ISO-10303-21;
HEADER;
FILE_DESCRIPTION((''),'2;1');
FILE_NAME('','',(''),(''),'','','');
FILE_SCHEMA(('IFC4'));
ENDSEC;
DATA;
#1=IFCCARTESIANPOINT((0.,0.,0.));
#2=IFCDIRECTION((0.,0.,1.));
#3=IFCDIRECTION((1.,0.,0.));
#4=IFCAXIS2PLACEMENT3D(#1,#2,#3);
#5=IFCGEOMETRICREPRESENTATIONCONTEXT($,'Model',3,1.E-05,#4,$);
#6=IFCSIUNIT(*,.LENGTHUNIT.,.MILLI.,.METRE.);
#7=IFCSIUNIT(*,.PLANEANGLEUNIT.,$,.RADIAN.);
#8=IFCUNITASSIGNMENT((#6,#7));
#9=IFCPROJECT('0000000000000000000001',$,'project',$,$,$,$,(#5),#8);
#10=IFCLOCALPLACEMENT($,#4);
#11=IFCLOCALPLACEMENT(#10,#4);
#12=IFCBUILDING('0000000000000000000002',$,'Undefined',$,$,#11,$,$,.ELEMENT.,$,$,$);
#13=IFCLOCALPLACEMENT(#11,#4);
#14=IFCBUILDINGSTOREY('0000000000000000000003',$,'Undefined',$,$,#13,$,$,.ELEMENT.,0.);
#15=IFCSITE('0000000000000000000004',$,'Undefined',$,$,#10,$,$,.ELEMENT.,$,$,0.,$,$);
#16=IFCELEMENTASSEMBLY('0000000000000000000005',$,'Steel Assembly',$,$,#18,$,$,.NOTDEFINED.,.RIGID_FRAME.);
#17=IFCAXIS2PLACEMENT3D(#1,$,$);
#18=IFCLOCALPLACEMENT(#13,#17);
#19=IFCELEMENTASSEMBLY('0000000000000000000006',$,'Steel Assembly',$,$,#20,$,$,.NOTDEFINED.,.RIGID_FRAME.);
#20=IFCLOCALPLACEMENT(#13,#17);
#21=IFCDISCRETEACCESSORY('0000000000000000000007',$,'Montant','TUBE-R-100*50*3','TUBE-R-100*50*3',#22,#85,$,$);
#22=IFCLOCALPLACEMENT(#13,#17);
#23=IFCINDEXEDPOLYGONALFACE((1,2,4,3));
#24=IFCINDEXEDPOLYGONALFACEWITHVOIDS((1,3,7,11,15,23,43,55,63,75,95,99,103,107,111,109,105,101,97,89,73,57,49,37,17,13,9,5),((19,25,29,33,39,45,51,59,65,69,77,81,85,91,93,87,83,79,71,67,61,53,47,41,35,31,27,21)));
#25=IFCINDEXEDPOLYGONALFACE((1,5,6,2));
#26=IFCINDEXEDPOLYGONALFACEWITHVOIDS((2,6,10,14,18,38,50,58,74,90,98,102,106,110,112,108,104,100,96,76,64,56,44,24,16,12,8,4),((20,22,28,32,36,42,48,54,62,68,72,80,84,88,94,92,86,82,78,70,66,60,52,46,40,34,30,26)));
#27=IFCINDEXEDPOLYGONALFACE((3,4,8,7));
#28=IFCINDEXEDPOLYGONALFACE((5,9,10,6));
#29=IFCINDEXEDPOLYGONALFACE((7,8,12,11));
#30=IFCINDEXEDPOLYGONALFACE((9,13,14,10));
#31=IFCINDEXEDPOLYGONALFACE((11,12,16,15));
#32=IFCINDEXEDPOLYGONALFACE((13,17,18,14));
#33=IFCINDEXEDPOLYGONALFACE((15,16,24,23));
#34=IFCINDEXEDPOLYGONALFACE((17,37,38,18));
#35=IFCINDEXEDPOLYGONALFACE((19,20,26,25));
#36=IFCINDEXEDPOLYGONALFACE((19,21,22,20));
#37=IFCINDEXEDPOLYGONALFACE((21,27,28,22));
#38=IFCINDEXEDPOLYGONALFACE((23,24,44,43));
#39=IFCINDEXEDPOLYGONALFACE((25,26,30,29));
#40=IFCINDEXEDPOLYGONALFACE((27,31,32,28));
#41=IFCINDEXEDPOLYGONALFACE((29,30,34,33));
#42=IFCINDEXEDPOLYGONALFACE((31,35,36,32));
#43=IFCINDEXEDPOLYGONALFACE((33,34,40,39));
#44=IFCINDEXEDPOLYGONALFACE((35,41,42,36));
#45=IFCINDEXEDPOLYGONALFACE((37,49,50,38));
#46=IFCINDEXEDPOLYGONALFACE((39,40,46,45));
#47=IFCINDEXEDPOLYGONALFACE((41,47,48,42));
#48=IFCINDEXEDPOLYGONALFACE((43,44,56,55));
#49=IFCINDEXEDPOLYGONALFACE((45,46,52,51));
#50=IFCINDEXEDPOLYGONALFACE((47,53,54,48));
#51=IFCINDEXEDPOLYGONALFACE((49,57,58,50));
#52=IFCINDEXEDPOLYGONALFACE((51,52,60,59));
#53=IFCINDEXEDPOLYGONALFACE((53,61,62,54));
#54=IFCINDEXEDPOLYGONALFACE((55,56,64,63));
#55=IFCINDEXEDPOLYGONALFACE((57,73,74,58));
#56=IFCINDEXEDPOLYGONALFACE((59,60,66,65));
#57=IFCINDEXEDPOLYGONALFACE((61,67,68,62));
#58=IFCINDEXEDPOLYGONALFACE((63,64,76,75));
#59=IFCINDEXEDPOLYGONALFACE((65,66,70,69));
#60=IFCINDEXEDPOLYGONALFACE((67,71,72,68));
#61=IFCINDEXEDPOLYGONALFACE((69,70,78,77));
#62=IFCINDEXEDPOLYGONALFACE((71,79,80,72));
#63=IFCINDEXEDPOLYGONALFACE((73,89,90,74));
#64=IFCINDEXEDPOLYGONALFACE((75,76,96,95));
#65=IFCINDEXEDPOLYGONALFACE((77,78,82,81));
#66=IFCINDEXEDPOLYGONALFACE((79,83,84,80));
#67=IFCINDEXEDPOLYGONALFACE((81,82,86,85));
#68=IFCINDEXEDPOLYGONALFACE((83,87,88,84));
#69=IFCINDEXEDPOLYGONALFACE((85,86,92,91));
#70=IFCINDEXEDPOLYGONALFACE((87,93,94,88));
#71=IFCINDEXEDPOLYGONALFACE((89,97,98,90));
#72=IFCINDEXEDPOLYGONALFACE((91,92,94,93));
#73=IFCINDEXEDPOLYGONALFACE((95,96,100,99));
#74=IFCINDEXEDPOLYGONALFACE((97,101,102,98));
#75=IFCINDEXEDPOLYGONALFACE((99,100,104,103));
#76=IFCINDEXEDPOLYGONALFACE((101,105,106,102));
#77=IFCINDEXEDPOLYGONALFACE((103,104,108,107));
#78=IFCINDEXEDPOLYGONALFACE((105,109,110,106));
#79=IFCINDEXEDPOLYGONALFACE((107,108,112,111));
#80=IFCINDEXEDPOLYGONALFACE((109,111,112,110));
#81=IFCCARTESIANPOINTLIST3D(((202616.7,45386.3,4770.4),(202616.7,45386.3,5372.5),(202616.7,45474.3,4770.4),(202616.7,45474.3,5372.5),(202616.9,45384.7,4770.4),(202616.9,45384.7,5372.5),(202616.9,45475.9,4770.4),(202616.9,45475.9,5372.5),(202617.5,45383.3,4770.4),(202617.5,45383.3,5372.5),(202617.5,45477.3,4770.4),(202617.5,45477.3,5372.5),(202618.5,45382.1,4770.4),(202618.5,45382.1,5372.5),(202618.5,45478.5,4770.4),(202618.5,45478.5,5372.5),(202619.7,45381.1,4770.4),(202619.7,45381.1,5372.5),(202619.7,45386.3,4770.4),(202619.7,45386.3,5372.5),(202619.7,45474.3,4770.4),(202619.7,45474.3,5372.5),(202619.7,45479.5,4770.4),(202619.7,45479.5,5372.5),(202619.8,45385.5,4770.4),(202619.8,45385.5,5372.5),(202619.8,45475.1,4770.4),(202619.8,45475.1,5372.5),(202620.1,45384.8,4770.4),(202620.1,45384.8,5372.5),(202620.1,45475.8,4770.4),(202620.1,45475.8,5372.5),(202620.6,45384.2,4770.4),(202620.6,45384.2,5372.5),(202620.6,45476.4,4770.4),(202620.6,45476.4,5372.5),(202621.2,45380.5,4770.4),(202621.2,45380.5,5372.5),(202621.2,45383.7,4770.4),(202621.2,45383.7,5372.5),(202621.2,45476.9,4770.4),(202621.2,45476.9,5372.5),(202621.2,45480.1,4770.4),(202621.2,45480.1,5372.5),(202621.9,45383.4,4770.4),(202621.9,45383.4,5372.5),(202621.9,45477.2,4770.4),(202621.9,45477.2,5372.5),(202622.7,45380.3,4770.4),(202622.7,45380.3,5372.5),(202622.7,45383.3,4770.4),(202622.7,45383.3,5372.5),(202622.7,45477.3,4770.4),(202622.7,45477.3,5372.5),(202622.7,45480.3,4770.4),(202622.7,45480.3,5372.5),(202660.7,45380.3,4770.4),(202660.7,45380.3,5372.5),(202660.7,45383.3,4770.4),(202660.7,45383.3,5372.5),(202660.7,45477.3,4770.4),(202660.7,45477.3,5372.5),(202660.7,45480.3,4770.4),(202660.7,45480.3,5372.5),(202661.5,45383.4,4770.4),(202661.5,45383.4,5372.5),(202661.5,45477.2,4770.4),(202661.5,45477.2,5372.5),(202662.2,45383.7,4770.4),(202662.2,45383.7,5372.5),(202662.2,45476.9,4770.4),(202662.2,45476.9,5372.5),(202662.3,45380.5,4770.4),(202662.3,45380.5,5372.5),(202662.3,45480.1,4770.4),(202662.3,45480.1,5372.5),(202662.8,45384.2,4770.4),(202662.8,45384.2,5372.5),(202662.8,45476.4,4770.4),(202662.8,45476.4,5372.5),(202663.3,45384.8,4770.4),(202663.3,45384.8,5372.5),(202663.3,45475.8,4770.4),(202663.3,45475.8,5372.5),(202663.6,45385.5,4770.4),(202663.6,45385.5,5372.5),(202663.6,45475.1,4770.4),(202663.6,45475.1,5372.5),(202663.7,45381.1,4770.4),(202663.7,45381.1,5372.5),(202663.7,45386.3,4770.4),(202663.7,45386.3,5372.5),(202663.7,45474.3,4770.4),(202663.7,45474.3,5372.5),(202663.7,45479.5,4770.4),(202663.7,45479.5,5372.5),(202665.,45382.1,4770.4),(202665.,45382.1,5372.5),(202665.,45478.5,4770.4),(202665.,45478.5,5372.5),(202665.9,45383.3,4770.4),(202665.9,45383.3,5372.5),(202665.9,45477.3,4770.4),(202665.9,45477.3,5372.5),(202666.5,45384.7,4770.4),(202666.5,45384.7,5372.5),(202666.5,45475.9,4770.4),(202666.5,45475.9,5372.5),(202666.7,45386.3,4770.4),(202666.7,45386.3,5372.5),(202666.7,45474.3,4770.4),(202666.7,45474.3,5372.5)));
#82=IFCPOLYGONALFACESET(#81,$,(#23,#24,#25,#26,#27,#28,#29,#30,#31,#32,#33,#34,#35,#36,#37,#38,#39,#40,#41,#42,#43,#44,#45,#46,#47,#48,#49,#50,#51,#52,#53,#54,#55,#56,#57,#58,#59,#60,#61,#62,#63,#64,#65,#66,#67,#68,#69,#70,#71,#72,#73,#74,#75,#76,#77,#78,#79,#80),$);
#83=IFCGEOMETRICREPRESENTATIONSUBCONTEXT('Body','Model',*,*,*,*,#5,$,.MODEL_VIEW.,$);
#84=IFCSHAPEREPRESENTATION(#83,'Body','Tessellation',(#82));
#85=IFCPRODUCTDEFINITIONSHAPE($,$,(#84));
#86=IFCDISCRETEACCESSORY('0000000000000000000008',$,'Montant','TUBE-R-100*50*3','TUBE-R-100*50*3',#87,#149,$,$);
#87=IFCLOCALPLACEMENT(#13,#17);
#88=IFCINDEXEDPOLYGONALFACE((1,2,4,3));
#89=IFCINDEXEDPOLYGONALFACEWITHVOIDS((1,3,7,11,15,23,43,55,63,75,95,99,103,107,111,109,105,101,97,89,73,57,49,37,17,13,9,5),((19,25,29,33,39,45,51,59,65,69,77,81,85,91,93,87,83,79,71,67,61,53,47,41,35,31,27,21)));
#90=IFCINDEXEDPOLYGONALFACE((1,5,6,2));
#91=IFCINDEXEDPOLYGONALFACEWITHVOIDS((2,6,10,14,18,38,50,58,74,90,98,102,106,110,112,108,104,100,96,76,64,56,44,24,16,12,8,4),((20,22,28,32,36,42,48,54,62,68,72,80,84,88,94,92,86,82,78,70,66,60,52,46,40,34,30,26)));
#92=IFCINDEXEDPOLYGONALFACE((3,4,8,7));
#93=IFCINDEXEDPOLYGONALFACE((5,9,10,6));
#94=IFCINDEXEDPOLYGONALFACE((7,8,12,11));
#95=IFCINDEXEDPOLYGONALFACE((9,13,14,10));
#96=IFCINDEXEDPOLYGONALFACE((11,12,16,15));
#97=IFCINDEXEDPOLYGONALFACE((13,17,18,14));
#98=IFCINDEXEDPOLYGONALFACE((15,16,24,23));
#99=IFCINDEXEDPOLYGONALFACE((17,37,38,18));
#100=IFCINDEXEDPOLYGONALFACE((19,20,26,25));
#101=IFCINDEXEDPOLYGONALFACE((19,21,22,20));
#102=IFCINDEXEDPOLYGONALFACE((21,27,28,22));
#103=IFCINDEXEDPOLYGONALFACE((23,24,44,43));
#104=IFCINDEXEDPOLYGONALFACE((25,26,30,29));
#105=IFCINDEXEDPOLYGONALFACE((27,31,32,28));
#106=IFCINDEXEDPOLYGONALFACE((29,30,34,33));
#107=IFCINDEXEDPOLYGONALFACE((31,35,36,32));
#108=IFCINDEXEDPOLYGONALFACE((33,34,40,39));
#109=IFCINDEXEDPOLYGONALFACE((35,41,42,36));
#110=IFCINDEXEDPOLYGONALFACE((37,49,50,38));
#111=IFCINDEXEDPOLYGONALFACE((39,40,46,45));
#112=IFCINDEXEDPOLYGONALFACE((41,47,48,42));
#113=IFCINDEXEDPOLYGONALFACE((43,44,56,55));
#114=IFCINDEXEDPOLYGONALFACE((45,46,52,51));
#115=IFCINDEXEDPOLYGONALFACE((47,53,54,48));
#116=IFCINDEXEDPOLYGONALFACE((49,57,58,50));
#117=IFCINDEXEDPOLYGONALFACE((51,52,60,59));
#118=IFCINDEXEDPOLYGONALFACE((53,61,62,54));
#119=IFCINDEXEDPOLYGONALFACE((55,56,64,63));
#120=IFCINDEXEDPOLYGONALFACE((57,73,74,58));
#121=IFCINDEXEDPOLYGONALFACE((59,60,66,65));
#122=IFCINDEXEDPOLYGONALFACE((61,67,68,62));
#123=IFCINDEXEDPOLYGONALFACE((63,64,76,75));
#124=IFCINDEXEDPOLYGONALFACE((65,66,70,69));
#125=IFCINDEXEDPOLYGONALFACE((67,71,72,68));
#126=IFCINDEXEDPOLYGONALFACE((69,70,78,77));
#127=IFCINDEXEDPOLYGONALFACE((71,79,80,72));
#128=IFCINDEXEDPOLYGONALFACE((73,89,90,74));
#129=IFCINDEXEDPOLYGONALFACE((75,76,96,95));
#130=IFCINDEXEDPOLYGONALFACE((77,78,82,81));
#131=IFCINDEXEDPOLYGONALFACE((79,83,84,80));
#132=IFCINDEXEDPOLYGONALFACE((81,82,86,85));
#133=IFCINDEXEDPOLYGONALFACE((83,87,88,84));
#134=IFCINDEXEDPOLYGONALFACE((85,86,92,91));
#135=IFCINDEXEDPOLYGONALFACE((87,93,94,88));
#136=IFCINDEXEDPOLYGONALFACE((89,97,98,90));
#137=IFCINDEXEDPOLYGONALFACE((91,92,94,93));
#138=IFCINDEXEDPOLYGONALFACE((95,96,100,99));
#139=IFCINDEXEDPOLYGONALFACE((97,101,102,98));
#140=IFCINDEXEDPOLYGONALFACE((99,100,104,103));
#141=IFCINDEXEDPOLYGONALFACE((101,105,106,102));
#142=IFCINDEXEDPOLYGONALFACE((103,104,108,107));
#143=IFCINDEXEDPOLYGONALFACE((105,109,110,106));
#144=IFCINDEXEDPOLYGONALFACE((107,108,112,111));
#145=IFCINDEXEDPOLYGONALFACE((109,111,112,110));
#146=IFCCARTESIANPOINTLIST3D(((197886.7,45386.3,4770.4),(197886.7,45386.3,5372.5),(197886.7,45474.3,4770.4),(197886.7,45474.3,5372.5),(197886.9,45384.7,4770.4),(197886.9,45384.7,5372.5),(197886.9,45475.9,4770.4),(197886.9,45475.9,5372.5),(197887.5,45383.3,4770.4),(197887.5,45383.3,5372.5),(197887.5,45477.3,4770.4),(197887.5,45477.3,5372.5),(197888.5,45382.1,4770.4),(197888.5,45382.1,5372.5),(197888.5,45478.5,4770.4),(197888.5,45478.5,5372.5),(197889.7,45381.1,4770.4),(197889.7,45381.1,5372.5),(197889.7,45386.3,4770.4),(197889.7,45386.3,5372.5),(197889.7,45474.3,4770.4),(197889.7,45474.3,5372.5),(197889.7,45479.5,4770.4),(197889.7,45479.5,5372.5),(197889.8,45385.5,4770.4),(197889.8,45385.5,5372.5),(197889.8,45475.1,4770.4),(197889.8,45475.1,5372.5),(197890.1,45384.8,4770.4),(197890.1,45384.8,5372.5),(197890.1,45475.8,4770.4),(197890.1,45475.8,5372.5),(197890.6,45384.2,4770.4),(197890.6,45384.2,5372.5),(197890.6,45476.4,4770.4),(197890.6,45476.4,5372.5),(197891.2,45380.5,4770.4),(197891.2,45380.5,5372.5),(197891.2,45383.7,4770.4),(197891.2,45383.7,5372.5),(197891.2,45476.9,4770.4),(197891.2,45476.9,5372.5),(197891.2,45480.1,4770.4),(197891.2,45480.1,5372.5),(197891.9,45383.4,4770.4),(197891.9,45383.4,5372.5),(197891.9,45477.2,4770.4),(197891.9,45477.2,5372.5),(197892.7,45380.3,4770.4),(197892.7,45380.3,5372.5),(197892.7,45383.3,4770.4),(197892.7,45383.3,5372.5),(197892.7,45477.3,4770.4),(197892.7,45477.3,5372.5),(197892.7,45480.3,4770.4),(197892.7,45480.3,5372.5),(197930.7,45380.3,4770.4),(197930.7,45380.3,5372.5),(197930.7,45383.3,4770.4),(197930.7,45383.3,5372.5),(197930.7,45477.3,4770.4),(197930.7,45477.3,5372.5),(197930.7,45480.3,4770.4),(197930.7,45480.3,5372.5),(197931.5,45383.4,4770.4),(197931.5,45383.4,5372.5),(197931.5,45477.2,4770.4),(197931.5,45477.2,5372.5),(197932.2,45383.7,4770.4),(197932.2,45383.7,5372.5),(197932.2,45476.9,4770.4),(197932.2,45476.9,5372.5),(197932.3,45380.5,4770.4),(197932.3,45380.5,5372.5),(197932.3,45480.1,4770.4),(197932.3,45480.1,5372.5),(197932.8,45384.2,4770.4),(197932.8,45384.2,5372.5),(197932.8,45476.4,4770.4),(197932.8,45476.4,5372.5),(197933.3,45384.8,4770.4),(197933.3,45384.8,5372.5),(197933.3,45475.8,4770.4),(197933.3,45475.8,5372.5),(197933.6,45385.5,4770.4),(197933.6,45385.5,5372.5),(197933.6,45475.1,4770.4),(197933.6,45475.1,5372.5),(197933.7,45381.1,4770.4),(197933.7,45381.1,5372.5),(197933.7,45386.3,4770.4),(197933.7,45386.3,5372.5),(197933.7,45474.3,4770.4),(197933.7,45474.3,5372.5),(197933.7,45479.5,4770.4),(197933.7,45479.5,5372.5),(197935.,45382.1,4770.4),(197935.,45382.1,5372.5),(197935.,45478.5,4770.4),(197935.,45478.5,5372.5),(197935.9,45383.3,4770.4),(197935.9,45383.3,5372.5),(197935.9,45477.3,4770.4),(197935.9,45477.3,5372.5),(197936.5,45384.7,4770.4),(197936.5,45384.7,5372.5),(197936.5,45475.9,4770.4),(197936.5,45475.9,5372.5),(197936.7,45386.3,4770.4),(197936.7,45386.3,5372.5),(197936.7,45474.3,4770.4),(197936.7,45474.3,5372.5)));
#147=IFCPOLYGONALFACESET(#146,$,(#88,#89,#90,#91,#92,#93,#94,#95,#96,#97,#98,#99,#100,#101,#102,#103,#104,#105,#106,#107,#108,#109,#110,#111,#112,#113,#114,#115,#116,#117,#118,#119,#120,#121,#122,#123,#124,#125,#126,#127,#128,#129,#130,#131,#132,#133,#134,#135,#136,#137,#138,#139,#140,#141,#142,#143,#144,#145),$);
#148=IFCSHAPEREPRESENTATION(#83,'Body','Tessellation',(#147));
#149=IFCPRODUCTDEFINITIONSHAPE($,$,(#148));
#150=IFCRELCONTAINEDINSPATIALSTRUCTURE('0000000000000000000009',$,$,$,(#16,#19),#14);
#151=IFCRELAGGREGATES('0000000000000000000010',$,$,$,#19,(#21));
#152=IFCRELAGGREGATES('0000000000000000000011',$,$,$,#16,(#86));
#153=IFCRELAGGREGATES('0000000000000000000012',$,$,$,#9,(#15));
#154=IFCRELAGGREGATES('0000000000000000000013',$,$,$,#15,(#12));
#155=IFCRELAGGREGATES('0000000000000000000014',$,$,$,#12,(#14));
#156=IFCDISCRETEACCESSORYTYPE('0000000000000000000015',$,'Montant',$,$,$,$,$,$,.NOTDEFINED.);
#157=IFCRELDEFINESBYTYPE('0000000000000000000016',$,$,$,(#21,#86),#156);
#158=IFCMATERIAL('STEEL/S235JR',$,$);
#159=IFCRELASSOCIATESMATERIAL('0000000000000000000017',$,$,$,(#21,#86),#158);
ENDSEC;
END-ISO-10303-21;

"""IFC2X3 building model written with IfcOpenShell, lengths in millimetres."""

from ifc_helpers import new_model, si_unit, frame, origin_with_axes, origin_2d_with_axis, place, context, subcontext, project, spatial, hollow_rectangle, extrude, material, type_object, element, aggregate, save


model = new_model("IFC2X3")

# Units and contexts
model_context = context("Model", 3, precision=1e-05, world=origin_with_axes())
body_context = subcontext(model_context, "Body", "Model", "MODEL_VIEW")
ifc_project = project(units=[si_unit("LENGTHUNIT", "METRE", prefix="MILLI"), si_unit("PLANEANGLEUNIT", "RADIAN")], contexts=[model_context])

# Site, building, storey
site_placement = place(None, origin_with_axes())
site = spatial("IfcSite", under=ifc_project, at=site_placement, Name="Undefined", CompositionType="ELEMENT", RefElevation=0.0)
building_placement = place(site_placement, origin_with_axes())
building = spatial("IfcBuilding", under=site, at=building_placement, Name="Undefined", CompositionType="ELEMENT")
storey_placement = place(building_placement, origin_with_axes())
storey = spatial("IfcBuildingStorey", under=building, at=storey_placement, Name="Undefined", CompositionType="ELEMENT", Elevation=0.0)

# Shared definitions
ifc_material_1 = material(Name="STEEL/S235JR")

# Element assembly
assembly_1_placement = place(storey_placement, origin_with_axes())
assembly_1 = element("IfcElementAssembly", 1, at=assembly_1_placement, inside=storey, Name="Steel Assembly", AssemblyPlace="NOTDEFINED", PredefinedType="RIGID_FRAME")

# Element assembly
assembly_2_placement = place(storey_placement, origin_with_axes())
assembly_2 = element("IfcElementAssembly", 2, at=assembly_2_placement, inside=storey, Name="Steel Assembly", AssemblyPlace="NOTDEFINED", PredefinedType="RIGID_FRAME")

# Discrete accessories
discrete_accessory_type_1 = type_object("IfcDiscreteAccessoryType", Name="Montant")
discrete_accessory_1_placement = place(assembly_2_placement, frame((202641.7, 45430.3, 4770.4), z_axis=(0.0, 0.0, 1.0), x_axis=(1.0, 0.0, 0.0)))
discrete_accessory_1 = element("IfcDiscreteAccessory", 3, at=discrete_accessory_1_placement, type_object=discrete_accessory_type_1, material=ifc_material_1, Name="Montant", Description="TUBE-R-100*50*3", ObjectType="TUBE-R-100*50*3", context=body_context, shape_type="SweptSolid", body=[
    extrude(hollow_rectangle(XDim=50.0, YDim=100.0, WallThickness=3.0, InnerFilletRadius=3.0, OuterFilletRadius=6.0, at=origin_2d_with_axis()), frame((0.0, 0.0, 602.1), z_axis=(0.0, 0.0, -1.0), x_axis=(1.0, 0.0, 0.0)), (0.0, 0.0, 1.0), 602.1),
])
aggregate(assembly_2, [discrete_accessory_1])
discrete_accessory_2_placement = place(assembly_1_placement, frame((197911.7, 45430.3, 4770.4), z_axis=(0.0, 0.0, 1.0), x_axis=(1.0, 0.0, 0.0)))
discrete_accessory_2 = element("IfcDiscreteAccessory", 4, at=discrete_accessory_2_placement, type_object=discrete_accessory_type_1, material=ifc_material_1, Name="Montant", Description="TUBE-R-100*50*3", ObjectType="TUBE-R-100*50*3", context=body_context, shape_type="SweptSolid", body=[
    extrude(hollow_rectangle(XDim=50.0, YDim=100.0, WallThickness=3.0, InnerFilletRadius=3.0, OuterFilletRadius=6.0, at=origin_2d_with_axis()), frame((0.0, 0.0, 602.1), z_axis=(0.0, 0.0, -1.0), x_axis=(1.0, 0.0, 0.0)), (0.0, 0.0, 1.0), 602.1),
])
aggregate(assembly_1, [discrete_accessory_2])

save(model, "model.ifc")
